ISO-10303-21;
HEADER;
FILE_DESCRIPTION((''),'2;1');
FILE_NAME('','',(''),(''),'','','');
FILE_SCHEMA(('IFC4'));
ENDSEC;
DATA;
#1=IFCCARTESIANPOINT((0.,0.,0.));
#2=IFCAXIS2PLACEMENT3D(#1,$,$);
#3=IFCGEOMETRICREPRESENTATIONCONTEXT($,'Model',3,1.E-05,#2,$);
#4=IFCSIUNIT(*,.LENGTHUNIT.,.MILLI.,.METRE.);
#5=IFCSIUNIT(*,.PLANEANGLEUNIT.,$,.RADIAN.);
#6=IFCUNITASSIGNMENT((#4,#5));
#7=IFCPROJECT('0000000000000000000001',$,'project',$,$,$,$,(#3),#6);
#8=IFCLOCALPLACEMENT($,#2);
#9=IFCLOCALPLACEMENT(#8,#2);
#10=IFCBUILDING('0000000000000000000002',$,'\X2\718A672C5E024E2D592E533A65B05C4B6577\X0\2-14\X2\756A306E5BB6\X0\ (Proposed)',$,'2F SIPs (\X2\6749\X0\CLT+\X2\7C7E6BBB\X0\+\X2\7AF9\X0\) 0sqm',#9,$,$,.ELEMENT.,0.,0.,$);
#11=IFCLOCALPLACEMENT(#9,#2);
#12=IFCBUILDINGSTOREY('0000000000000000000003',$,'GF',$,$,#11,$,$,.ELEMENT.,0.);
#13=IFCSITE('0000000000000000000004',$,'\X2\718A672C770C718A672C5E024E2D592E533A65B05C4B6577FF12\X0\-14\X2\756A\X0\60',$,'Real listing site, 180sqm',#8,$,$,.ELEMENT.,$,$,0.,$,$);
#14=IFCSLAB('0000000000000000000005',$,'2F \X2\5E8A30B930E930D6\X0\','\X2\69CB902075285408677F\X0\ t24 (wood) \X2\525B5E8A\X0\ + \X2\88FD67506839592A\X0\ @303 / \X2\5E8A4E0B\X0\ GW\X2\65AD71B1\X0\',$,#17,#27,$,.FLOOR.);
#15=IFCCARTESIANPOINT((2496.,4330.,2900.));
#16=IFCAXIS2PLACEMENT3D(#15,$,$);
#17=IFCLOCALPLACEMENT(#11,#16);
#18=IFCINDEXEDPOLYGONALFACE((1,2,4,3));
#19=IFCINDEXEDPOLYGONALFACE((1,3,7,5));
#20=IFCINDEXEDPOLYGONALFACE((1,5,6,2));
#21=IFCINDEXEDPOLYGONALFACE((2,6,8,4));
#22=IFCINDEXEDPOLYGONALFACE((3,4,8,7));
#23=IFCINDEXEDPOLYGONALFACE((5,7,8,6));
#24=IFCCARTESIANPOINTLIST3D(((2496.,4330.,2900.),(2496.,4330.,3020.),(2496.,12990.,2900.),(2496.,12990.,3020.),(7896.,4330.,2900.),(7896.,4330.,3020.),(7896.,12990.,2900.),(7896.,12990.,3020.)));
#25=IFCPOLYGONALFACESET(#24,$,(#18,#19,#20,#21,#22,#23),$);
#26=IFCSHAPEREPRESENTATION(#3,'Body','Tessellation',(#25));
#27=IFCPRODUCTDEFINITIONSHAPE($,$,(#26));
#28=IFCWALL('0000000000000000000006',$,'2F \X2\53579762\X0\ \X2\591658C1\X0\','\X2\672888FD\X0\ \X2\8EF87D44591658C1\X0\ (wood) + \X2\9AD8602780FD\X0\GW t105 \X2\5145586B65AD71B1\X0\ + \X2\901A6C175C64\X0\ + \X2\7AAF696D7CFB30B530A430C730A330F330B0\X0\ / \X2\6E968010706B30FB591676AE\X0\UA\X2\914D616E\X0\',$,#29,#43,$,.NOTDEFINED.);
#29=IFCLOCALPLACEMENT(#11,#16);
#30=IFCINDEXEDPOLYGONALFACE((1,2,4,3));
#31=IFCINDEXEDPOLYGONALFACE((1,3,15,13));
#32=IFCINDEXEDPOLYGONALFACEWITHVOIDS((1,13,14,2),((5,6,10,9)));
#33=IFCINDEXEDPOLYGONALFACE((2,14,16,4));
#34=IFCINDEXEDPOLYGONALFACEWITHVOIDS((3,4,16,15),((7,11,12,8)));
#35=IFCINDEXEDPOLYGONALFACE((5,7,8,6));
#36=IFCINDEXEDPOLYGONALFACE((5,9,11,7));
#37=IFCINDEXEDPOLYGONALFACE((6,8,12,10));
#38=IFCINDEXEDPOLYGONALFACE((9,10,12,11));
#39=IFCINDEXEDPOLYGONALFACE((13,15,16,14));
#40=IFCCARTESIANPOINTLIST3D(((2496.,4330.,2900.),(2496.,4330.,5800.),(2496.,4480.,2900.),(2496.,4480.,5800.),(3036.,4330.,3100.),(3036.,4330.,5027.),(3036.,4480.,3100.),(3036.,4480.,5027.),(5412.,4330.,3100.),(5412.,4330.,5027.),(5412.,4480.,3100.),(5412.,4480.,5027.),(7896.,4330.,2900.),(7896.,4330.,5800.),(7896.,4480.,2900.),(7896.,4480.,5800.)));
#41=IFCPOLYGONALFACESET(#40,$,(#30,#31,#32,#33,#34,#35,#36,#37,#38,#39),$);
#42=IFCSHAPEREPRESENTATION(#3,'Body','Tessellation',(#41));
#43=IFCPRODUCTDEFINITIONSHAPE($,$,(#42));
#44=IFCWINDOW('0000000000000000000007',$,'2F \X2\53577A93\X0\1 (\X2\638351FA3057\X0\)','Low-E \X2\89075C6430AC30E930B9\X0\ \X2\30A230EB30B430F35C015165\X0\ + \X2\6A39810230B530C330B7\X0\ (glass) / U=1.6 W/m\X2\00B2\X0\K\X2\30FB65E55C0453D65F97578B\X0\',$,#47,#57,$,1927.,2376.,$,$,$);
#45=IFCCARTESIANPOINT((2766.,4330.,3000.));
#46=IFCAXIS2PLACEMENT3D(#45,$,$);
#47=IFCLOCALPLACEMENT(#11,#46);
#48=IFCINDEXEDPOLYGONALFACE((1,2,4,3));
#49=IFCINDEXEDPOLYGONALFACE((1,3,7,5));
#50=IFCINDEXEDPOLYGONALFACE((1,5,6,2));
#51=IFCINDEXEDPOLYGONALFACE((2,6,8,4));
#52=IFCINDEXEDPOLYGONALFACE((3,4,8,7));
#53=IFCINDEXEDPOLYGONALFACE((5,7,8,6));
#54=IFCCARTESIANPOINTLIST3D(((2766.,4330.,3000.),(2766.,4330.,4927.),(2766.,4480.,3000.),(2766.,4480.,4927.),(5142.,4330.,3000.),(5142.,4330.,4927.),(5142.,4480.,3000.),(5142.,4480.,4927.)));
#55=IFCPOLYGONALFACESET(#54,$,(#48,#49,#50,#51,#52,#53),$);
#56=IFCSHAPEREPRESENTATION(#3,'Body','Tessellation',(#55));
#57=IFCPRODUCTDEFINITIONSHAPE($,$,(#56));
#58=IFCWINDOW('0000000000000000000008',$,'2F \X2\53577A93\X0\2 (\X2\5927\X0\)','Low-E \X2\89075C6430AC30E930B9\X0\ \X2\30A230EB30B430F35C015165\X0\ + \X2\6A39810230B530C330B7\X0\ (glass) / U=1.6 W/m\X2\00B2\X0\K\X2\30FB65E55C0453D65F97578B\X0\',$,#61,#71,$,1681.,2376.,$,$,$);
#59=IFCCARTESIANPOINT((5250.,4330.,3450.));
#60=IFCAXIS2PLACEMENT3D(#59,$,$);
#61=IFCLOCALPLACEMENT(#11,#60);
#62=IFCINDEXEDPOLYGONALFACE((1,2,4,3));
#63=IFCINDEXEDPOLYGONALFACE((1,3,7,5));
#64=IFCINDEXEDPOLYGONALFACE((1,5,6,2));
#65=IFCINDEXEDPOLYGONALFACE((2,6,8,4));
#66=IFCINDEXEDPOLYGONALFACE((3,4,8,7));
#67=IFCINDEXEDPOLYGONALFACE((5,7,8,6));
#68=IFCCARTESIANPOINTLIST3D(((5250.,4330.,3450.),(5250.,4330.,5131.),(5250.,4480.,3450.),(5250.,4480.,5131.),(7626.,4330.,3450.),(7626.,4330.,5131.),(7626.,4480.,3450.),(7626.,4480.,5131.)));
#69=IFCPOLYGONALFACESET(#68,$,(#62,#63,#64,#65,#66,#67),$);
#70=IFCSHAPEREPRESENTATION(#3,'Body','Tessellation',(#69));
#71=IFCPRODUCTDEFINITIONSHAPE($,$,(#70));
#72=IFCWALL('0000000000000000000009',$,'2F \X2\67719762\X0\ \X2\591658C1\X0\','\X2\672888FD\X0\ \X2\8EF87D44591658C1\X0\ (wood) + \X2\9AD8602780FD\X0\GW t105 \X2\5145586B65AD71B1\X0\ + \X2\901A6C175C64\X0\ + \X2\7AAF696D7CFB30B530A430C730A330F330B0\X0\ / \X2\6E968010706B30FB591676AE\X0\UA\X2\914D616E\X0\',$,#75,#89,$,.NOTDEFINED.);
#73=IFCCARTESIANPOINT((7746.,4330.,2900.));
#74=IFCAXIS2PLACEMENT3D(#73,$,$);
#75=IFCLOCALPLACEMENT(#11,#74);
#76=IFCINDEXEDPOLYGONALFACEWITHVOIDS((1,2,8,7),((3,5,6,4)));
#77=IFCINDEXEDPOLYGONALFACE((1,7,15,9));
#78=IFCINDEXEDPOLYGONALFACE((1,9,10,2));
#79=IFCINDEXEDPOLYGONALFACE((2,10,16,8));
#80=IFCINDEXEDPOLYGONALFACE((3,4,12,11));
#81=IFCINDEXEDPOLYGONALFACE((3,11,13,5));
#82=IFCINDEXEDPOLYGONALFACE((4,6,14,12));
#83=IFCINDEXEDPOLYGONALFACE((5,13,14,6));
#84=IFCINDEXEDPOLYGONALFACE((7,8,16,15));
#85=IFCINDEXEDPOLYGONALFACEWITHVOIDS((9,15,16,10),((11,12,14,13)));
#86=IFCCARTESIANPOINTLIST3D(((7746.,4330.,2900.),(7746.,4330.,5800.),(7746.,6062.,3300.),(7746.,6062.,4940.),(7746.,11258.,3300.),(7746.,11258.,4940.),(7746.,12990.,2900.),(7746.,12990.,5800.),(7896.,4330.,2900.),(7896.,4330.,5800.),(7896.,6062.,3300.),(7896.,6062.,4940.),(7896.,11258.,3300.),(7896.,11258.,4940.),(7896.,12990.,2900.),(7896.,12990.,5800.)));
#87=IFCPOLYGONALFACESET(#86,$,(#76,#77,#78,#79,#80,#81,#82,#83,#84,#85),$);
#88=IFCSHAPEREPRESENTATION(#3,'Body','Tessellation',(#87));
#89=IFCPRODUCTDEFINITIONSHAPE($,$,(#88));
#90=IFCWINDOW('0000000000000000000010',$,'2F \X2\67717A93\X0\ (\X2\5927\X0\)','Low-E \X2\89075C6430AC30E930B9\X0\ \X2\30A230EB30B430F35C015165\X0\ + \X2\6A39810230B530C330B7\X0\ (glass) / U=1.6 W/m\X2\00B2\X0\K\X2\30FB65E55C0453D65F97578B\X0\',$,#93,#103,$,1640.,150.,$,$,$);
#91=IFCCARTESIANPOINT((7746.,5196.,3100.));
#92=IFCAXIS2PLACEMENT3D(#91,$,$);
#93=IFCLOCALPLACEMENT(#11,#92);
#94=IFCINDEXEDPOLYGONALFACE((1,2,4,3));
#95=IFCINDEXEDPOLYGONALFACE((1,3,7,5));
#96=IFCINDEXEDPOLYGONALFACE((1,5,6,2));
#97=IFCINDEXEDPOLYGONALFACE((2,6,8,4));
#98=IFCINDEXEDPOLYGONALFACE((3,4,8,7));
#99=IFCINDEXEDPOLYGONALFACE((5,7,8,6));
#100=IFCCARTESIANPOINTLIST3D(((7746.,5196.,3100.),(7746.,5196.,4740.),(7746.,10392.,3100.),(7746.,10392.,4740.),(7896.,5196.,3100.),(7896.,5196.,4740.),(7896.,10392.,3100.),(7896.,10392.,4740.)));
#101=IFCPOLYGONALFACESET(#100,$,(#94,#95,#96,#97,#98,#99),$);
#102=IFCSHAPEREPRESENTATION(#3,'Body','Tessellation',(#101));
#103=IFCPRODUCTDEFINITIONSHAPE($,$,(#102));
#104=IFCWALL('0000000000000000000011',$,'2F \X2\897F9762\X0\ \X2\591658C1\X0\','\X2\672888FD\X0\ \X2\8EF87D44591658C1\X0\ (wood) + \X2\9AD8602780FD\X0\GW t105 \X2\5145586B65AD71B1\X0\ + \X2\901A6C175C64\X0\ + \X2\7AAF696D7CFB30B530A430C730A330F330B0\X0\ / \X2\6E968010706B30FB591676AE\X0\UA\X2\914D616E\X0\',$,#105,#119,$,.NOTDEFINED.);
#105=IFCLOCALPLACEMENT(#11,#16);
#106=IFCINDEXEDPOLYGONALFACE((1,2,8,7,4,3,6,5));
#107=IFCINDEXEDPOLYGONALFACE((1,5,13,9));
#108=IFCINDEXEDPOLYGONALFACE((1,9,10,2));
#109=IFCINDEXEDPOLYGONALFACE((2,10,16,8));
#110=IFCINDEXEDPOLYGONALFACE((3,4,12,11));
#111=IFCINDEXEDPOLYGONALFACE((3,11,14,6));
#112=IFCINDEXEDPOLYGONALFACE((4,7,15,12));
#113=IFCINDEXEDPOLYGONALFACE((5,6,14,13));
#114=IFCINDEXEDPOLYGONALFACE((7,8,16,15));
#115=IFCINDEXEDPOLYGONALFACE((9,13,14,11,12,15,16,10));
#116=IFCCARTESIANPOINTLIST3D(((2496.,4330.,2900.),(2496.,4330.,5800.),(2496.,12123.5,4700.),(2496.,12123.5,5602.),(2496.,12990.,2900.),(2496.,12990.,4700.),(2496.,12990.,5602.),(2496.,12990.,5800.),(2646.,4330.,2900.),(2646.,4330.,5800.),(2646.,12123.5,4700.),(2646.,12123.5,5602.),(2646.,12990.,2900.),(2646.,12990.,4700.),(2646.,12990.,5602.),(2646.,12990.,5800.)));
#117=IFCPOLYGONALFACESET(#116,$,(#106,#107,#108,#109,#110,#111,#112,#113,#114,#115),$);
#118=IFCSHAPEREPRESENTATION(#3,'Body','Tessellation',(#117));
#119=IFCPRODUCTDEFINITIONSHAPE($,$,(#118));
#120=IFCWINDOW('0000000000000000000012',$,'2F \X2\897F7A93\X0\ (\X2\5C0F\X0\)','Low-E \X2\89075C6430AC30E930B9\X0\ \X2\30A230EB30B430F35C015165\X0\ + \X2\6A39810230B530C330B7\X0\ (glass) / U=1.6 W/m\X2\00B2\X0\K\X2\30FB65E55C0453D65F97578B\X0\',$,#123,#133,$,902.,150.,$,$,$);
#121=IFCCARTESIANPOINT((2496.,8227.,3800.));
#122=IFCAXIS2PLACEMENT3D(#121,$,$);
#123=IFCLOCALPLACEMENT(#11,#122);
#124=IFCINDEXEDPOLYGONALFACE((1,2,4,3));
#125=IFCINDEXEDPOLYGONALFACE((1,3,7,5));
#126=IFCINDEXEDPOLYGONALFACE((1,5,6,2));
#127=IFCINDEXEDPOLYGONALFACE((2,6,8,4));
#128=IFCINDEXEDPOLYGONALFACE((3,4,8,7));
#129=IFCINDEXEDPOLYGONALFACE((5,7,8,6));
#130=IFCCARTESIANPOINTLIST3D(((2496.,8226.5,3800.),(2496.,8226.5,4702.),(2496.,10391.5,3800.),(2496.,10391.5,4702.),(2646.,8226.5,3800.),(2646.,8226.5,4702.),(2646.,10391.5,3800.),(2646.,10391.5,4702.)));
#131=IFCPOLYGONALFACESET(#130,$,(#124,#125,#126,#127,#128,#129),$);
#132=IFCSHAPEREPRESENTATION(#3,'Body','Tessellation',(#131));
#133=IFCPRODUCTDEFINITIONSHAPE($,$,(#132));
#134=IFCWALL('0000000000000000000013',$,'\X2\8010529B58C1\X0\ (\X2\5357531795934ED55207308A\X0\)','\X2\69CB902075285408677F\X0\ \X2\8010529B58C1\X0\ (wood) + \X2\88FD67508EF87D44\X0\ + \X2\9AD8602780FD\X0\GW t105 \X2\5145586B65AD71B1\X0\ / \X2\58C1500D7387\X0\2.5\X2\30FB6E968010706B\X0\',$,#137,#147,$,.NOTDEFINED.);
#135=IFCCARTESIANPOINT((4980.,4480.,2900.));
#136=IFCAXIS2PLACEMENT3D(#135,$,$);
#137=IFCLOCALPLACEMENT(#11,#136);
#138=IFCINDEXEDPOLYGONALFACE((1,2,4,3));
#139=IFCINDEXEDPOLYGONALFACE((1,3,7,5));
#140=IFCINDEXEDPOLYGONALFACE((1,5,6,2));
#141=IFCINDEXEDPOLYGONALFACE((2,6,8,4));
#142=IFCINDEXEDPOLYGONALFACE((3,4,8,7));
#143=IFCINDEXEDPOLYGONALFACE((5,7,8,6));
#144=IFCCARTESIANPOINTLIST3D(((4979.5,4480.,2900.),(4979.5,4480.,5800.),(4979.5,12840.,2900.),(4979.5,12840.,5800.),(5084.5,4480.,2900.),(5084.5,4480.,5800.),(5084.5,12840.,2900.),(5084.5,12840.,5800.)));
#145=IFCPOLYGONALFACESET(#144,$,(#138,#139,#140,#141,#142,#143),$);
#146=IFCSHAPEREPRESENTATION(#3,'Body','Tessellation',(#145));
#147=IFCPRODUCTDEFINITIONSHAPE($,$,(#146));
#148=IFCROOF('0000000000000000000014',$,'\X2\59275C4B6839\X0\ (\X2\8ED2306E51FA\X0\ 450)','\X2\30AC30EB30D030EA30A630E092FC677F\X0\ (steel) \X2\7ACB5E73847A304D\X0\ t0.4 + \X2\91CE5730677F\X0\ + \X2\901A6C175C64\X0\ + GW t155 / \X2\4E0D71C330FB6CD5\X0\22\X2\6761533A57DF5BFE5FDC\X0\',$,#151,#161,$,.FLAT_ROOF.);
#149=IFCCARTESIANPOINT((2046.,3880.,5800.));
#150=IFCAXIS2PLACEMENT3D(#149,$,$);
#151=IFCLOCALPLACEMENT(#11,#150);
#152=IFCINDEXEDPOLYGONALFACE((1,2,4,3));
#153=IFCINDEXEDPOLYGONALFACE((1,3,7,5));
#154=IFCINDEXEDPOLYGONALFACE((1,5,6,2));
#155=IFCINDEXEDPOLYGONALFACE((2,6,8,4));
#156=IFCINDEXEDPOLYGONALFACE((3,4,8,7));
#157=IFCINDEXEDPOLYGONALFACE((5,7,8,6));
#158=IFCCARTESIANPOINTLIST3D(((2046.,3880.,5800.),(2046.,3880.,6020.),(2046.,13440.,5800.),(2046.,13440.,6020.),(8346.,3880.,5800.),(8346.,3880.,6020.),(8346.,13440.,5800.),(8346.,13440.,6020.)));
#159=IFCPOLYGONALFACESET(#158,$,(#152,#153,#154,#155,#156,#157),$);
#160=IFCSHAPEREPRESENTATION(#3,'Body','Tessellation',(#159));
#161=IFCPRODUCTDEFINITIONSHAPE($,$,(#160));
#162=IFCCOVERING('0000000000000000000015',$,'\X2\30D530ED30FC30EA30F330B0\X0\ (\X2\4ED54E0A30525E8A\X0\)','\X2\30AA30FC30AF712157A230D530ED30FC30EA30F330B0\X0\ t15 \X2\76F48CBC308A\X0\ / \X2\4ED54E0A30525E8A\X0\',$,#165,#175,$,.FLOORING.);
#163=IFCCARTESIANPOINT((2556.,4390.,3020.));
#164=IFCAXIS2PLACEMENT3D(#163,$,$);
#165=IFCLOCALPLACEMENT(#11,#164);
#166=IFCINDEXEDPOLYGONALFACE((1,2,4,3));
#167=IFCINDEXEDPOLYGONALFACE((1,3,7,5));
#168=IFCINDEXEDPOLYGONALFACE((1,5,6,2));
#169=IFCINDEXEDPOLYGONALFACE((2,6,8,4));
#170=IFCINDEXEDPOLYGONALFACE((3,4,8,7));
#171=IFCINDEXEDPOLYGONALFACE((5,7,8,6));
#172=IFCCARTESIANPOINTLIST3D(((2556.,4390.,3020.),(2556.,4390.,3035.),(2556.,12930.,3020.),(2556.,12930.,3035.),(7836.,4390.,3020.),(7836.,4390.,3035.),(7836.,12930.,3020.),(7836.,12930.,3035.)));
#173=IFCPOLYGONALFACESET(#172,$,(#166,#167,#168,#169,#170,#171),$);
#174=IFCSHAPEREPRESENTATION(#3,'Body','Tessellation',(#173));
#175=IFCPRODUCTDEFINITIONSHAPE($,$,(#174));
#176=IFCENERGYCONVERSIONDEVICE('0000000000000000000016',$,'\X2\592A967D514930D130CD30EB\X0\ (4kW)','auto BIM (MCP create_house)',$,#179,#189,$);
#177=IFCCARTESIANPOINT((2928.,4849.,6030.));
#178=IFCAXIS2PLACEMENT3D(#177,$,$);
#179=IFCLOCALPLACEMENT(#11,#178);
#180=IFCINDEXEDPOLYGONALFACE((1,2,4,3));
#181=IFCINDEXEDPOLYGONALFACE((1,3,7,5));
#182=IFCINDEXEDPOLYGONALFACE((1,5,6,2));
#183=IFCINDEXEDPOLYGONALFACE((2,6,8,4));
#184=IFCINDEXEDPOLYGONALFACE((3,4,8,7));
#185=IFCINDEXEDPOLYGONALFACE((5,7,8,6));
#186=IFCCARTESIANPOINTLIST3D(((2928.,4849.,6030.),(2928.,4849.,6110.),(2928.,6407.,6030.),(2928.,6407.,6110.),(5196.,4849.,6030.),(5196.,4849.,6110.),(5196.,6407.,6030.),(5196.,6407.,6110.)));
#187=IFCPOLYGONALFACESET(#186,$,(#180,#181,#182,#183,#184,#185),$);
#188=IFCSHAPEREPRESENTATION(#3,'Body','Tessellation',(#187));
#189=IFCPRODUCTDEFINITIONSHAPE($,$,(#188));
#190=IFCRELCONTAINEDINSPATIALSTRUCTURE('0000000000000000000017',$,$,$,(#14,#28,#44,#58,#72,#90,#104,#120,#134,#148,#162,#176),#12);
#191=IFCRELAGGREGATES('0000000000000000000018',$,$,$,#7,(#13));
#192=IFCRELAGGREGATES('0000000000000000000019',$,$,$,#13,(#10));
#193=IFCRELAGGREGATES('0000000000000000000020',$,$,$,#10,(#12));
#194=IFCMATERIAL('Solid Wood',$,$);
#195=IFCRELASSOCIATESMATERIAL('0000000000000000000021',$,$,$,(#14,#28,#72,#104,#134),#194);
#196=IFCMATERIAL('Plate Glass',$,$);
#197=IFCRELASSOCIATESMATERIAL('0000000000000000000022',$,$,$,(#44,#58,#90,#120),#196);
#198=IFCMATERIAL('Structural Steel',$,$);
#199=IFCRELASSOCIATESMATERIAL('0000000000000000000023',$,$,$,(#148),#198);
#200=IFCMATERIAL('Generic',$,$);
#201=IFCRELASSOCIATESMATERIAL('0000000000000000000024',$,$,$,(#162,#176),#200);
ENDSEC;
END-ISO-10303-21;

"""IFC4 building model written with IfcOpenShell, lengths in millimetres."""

from ifc_helpers import new_model, si_unit, frame, frame_2d, origin, place, context, project, spatial, rectangle, extrude, material, element, fill, save


model = new_model("IFC4")

# Units and contexts
model_context = context("Model", 3, precision=1e-05, world=origin())
ifc_project = project(units=[si_unit("LENGTHUNIT", "METRE", prefix="MILLI"), si_unit("PLANEANGLEUNIT", "RADIAN")], contexts=[model_context])

# Site, building, storey
site_placement = place(None, origin())
site = spatial("IfcSite", under=ifc_project, at=site_placement, Name="熊本県熊本市中央区新屋敷２-14番60", ObjectType="Real listing site, 180sqm", CompositionType="ELEMENT", RefElevation=0.0)
building_placement = place(site_placement, origin())
building = spatial("IfcBuilding", under=site, at=building_placement, Name="熊本市中央区新屋敷2-14番の家 (Proposed)", ObjectType="2F SIPs (杉CLT+籾殻+竹) 0sqm", CompositionType="ELEMENT", ElevationOfRefHeight=0.0, ElevationOfTerrain=0.0)
storey_placement = place(building_placement, origin())
storey = spatial("IfcBuildingStorey", under=building, at=storey_placement, Name="GF", CompositionType="ELEMENT", Elevation=0.0)

# Slab
ifc_material_1 = material(Name="Solid Wood")
slab_placement = place(storey_placement, frame((2496.0, 4330.0, 2900.0)))
element("IfcSlab", 1, at=slab_placement, inside=storey, material=ifc_material_1, Name="2F 床スラブ", Description="構造用合板 t24 (wood) 剛床 + 製材根太 @303 / 床下 GW断熱", PredefinedType="FLOOR", context=model_context, shape_type="SweptSolid", body=[
    extrude(rectangle(XDim=5400.0, YDim=8660.0, at=frame_2d((2700.0, 4330.0))), frame((2496.0, 4330.0, 2900.0)), (0.0, 0.0, 1.0), 120.0),
])

# Wall, openings, windows
wall_1_placement = place(storey_placement, frame((2496.0, 4330.0, 2900.0)))
wall_1 = element("IfcWall", 2, at=wall_1_placement, inside=storey, material=ifc_material_1, Name="2F 南面 外壁", Description="木製 軸組外壁 (wood) + 高性能GW t105 充填断熱 + 通気層 + 窯業系サイディング / 準耐火・外皮UA配慮", PredefinedType="NOTDEFINED", context=model_context, shape_type="SweptSolid", body=[
    extrude(rectangle(XDim=5400.0, YDim=150.0, at=frame_2d((2700.0, 75.0))), frame((2496.0, 4330.0, 2900.0)), (0.0, 0.0, 1.0), 2900.0),
])
opening_1_placement = place(storey_placement, frame((2766.0, 4330.0, 3000.0)))
opening_1 = element("IfcOpeningElement", 3, at=opening_1_placement, cuts=wall_1, PredefinedType="NOTDEFINED", context=model_context, shape_type="SweptSolid", body=[
    extrude(rectangle(XDim=2376.0, YDim=150.0, at=frame_2d((1188.0, 75.0))), frame((2766.0, 4330.0, 3000.0)), (0.0, 0.0, 1.0), 1927.0),
])
opening_2_placement = place(storey_placement, frame((5250.0, 4330.0, 3450.0)))
opening_2 = element("IfcOpeningElement", 4, at=opening_2_placement, cuts=wall_1, PredefinedType="NOTDEFINED", context=model_context, shape_type="SweptSolid", body=[
    extrude(rectangle(XDim=2376.0, YDim=150.0, at=frame_2d((1188.0, 75.0))), frame((5250.0, 4330.0, 3450.0)), (0.0, 0.0, 1.0), 1681.0),
])
ifc_material_2 = material(Name="Plate Glass")
window_1_placement = place(storey_placement, frame((2766.0, 4330.0, 3000.0)))
window_1 = element("IfcWindow", 5, at=window_1_placement, inside=storey, material=ifc_material_2, Name="2F 南窓1 (掃出し)", Description="Low-E 複層ガラス アルゴン封入 + 樹脂サッシ (glass) / U=1.6 W/m²K・日射取得型", OverallHeight=1927.0, OverallWidth=2376.0, context=model_context, shape_type="SweptSolid", body=[
    extrude(rectangle(XDim=2376.0, YDim=150.0, at=frame_2d((1188.0, 75.0))), frame((2766.0, 4330.0, 3000.0)), (0.0, 0.0, 1.0), 1927.0),
])
fill(opening_1, window_1)
window_2_placement = place(storey_placement, frame((5250.0, 4330.0, 3450.0)))
window_2 = element("IfcWindow", 6, at=window_2_placement, inside=storey, material=ifc_material_2, Name="2F 南窓2 (大)", Description="Low-E 複層ガラス アルゴン封入 + 樹脂サッシ (glass) / U=1.6 W/m²K・日射取得型", OverallHeight=1681.0, OverallWidth=2376.0, context=model_context, shape_type="SweptSolid", body=[
    extrude(rectangle(XDim=2376.0, YDim=150.0, at=frame_2d((1188.0, 75.0))), frame((5250.0, 4330.0, 3450.0)), (0.0, 0.0, 1.0), 1681.0),
])
fill(opening_2, window_2)

# Walls, openings, windows
wall_2_placement = place(storey_placement, frame((7746.0, 4330.0, 2900.0)))
wall_2 = element("IfcWall", 7, at=wall_2_placement, inside=storey, material=ifc_material_1, Name="2F 東面 外壁", Description="木製 軸組外壁 (wood) + 高性能GW t105 充填断熱 + 通気層 + 窯業系サイディング / 準耐火・外皮UA配慮", PredefinedType="NOTDEFINED", context=model_context, shape_type="SweptSolid", body=[
    extrude(rectangle(XDim=150.0, YDim=8660.0, at=frame_2d((75.0, 4330.0))), frame((7746.0, 4330.0, 2900.0)), (0.0, 0.0, 1.0), 2900.0),
])
opening_3_placement = place(storey_placement, frame((7746.0, 5196.0, 3100.0)))
opening_3 = element("IfcOpeningElement", 8, at=opening_3_placement, cuts=wall_2, PredefinedType="NOTDEFINED", context=model_context, shape_type="SweptSolid", body=[
    extrude(rectangle(XDim=150.0, YDim=5196.0, at=frame_2d((75.0, 2598.0))), frame((7746.0, 5196.0, 3100.0)), (0.0, 0.0, 1.0), 1640.0),
])
window_3_placement = place(storey_placement, frame((7746.0, 5196.0, 3100.0)))
window_3 = element("IfcWindow", 9, at=window_3_placement, inside=storey, material=ifc_material_2, Name="2F 東窓 (大)", Description="Low-E 複層ガラス アルゴン封入 + 樹脂サッシ (glass) / U=1.6 W/m²K・日射取得型", OverallHeight=1640.0, OverallWidth=150.0, context=model_context, shape_type="SweptSolid", body=[
    extrude(rectangle(XDim=150.0, YDim=5196.0, at=frame_2d((75.0, 2598.0))), frame((7746.0, 5196.0, 3100.0)), (0.0, 0.0, 1.0), 1640.0),
])
fill(opening_3, window_3)
wall_3_placement = place(storey_placement, frame((2496.0, 4330.0, 2900.0)))
wall_3 = element("IfcWall", 10, at=wall_3_placement, inside=storey, material=ifc_material_1, Name="2F 西面 外壁", Description="木製 軸組外壁 (wood) + 高性能GW t105 充填断熱 + 通気層 + 窯業系サイディング / 準耐火・外皮UA配慮", PredefinedType="NOTDEFINED", context=model_context, shape_type="SweptSolid", body=[
    extrude(rectangle(XDim=150.0, YDim=8660.0, at=frame_2d((75.0, 4330.0))), frame((2496.0, 4330.0, 2900.0)), (0.0, 0.0, 1.0), 2900.0),
])
opening_4_placement = place(storey_placement, frame((2496.0, 8227.0, 3800.0)))
opening_4 = element("IfcOpeningElement", 11, at=opening_4_placement, cuts=wall_3, PredefinedType="NOTDEFINED", context=model_context, shape_type="SweptSolid", body=[
    extrude(rectangle(XDim=150.0, YDim=2165.0, at=frame_2d((75.0, 1082.0))), frame((2496.0, 8227.0, 3800.0)), (0.0, 0.0, 1.0), 902.0),
])
window_4_placement = place(storey_placement, frame((2496.0, 8227.0, 3800.0)))
window_4 = element("IfcWindow", 12, at=window_4_placement, inside=storey, material=ifc_material_2, Name="2F 西窓 (小)", Description="Low-E 複層ガラス アルゴン封入 + 樹脂サッシ (glass) / U=1.6 W/m²K・日射取得型", OverallHeight=902.0, OverallWidth=150.0, context=model_context, shape_type="SweptSolid", body=[
    extrude(rectangle(XDim=150.0, YDim=2165.0, at=frame_2d((75.0, 1082.0))), frame((2496.0, 8227.0, 3800.0)), (0.0, 0.0, 1.0), 902.0),
])
fill(opening_4, window_4)

# Wall
wall_4_placement = place(storey_placement, frame((4980.0, 4480.0, 2900.0)))
element("IfcWall", 13, at=wall_4_placement, inside=storey, material=ifc_material_1, Name="耐力壁 (南北間仕切り)", Description="構造用合板 耐力壁 (wood) + 製材軸組 + 高性能GW t105 充填断熱 / 壁倍率2.5・準耐火", PredefinedType="NOTDEFINED", context=model_context, shape_type="SweptSolid", body=[
    extrude(rectangle(XDim=105.0, YDim=8360.0, at=frame_2d((52.0, 4180.0))), frame((4980.0, 4480.0, 2900.0)), (0.0, 0.0, 1.0), 2900.0),
])

# Roof
ifc_material_3 = material(Name="Structural Steel")
roof_placement = place(storey_placement, frame((2046.0, 3880.0, 5800.0)))
element("IfcRoof", 14, at=roof_placement, inside=storey, material=ifc_material_3, Name="大屋根 (軒の出 450)", Description="ガルバリウム鋼板 (steel) 立平葺き t0.4 + 野地板 + 通気層 + GW t155 / 不燃・法22条区域対応", PredefinedType="FLAT_ROOF", context=model_context, shape_type="SweptSolid", body=[
    extrude(rectangle(XDim=6300.0, YDim=9560.0, at=frame_2d((3150.0, 4780.0))), frame((2046.0, 3880.0, 5800.0)), (0.0, 0.0, 1.0), 220.0),
])

# Covering
ifc_material_4 = material(Name="Generic")
covering_placement = place(storey_placement, frame((2556.0, 4390.0, 3020.0)))
element("IfcCovering", 15, at=covering_placement, inside=storey, material=ifc_material_4, Name="フローリング (仕上げ床)", Description="オーク無垢フローリング t15 直貼り / 仕上げ床", PredefinedType="FLOORING", context=model_context, shape_type="SweptSolid", body=[
    extrude(rectangle(XDim=5280.0, YDim=8540.0, at=frame_2d((2640.0, 4270.0))), frame((2556.0, 4390.0, 3020.0)), (0.0, 0.0, 1.0), 15.0),
])

# Energy conversion device
energy_conversion_device_placement = place(storey_placement, frame((2928.0, 4849.0, 6030.0)))
element("IfcEnergyConversionDevice", 16, at=energy_conversion_device_placement, inside=storey, material=ifc_material_4, Name="太陽光パネル (4kW)", Description="auto BIM (MCP create_house)", context=model_context, shape_type="SweptSolid", body=[
    extrude(rectangle(XDim=2268.0, YDim=1558.0, at=frame_2d((1134.0, 779.0))), frame((2928.0, 4849.0, 6030.0)), (0.0, 0.0, 1.0), 80.0),
])

save(model, "model.ifc")
